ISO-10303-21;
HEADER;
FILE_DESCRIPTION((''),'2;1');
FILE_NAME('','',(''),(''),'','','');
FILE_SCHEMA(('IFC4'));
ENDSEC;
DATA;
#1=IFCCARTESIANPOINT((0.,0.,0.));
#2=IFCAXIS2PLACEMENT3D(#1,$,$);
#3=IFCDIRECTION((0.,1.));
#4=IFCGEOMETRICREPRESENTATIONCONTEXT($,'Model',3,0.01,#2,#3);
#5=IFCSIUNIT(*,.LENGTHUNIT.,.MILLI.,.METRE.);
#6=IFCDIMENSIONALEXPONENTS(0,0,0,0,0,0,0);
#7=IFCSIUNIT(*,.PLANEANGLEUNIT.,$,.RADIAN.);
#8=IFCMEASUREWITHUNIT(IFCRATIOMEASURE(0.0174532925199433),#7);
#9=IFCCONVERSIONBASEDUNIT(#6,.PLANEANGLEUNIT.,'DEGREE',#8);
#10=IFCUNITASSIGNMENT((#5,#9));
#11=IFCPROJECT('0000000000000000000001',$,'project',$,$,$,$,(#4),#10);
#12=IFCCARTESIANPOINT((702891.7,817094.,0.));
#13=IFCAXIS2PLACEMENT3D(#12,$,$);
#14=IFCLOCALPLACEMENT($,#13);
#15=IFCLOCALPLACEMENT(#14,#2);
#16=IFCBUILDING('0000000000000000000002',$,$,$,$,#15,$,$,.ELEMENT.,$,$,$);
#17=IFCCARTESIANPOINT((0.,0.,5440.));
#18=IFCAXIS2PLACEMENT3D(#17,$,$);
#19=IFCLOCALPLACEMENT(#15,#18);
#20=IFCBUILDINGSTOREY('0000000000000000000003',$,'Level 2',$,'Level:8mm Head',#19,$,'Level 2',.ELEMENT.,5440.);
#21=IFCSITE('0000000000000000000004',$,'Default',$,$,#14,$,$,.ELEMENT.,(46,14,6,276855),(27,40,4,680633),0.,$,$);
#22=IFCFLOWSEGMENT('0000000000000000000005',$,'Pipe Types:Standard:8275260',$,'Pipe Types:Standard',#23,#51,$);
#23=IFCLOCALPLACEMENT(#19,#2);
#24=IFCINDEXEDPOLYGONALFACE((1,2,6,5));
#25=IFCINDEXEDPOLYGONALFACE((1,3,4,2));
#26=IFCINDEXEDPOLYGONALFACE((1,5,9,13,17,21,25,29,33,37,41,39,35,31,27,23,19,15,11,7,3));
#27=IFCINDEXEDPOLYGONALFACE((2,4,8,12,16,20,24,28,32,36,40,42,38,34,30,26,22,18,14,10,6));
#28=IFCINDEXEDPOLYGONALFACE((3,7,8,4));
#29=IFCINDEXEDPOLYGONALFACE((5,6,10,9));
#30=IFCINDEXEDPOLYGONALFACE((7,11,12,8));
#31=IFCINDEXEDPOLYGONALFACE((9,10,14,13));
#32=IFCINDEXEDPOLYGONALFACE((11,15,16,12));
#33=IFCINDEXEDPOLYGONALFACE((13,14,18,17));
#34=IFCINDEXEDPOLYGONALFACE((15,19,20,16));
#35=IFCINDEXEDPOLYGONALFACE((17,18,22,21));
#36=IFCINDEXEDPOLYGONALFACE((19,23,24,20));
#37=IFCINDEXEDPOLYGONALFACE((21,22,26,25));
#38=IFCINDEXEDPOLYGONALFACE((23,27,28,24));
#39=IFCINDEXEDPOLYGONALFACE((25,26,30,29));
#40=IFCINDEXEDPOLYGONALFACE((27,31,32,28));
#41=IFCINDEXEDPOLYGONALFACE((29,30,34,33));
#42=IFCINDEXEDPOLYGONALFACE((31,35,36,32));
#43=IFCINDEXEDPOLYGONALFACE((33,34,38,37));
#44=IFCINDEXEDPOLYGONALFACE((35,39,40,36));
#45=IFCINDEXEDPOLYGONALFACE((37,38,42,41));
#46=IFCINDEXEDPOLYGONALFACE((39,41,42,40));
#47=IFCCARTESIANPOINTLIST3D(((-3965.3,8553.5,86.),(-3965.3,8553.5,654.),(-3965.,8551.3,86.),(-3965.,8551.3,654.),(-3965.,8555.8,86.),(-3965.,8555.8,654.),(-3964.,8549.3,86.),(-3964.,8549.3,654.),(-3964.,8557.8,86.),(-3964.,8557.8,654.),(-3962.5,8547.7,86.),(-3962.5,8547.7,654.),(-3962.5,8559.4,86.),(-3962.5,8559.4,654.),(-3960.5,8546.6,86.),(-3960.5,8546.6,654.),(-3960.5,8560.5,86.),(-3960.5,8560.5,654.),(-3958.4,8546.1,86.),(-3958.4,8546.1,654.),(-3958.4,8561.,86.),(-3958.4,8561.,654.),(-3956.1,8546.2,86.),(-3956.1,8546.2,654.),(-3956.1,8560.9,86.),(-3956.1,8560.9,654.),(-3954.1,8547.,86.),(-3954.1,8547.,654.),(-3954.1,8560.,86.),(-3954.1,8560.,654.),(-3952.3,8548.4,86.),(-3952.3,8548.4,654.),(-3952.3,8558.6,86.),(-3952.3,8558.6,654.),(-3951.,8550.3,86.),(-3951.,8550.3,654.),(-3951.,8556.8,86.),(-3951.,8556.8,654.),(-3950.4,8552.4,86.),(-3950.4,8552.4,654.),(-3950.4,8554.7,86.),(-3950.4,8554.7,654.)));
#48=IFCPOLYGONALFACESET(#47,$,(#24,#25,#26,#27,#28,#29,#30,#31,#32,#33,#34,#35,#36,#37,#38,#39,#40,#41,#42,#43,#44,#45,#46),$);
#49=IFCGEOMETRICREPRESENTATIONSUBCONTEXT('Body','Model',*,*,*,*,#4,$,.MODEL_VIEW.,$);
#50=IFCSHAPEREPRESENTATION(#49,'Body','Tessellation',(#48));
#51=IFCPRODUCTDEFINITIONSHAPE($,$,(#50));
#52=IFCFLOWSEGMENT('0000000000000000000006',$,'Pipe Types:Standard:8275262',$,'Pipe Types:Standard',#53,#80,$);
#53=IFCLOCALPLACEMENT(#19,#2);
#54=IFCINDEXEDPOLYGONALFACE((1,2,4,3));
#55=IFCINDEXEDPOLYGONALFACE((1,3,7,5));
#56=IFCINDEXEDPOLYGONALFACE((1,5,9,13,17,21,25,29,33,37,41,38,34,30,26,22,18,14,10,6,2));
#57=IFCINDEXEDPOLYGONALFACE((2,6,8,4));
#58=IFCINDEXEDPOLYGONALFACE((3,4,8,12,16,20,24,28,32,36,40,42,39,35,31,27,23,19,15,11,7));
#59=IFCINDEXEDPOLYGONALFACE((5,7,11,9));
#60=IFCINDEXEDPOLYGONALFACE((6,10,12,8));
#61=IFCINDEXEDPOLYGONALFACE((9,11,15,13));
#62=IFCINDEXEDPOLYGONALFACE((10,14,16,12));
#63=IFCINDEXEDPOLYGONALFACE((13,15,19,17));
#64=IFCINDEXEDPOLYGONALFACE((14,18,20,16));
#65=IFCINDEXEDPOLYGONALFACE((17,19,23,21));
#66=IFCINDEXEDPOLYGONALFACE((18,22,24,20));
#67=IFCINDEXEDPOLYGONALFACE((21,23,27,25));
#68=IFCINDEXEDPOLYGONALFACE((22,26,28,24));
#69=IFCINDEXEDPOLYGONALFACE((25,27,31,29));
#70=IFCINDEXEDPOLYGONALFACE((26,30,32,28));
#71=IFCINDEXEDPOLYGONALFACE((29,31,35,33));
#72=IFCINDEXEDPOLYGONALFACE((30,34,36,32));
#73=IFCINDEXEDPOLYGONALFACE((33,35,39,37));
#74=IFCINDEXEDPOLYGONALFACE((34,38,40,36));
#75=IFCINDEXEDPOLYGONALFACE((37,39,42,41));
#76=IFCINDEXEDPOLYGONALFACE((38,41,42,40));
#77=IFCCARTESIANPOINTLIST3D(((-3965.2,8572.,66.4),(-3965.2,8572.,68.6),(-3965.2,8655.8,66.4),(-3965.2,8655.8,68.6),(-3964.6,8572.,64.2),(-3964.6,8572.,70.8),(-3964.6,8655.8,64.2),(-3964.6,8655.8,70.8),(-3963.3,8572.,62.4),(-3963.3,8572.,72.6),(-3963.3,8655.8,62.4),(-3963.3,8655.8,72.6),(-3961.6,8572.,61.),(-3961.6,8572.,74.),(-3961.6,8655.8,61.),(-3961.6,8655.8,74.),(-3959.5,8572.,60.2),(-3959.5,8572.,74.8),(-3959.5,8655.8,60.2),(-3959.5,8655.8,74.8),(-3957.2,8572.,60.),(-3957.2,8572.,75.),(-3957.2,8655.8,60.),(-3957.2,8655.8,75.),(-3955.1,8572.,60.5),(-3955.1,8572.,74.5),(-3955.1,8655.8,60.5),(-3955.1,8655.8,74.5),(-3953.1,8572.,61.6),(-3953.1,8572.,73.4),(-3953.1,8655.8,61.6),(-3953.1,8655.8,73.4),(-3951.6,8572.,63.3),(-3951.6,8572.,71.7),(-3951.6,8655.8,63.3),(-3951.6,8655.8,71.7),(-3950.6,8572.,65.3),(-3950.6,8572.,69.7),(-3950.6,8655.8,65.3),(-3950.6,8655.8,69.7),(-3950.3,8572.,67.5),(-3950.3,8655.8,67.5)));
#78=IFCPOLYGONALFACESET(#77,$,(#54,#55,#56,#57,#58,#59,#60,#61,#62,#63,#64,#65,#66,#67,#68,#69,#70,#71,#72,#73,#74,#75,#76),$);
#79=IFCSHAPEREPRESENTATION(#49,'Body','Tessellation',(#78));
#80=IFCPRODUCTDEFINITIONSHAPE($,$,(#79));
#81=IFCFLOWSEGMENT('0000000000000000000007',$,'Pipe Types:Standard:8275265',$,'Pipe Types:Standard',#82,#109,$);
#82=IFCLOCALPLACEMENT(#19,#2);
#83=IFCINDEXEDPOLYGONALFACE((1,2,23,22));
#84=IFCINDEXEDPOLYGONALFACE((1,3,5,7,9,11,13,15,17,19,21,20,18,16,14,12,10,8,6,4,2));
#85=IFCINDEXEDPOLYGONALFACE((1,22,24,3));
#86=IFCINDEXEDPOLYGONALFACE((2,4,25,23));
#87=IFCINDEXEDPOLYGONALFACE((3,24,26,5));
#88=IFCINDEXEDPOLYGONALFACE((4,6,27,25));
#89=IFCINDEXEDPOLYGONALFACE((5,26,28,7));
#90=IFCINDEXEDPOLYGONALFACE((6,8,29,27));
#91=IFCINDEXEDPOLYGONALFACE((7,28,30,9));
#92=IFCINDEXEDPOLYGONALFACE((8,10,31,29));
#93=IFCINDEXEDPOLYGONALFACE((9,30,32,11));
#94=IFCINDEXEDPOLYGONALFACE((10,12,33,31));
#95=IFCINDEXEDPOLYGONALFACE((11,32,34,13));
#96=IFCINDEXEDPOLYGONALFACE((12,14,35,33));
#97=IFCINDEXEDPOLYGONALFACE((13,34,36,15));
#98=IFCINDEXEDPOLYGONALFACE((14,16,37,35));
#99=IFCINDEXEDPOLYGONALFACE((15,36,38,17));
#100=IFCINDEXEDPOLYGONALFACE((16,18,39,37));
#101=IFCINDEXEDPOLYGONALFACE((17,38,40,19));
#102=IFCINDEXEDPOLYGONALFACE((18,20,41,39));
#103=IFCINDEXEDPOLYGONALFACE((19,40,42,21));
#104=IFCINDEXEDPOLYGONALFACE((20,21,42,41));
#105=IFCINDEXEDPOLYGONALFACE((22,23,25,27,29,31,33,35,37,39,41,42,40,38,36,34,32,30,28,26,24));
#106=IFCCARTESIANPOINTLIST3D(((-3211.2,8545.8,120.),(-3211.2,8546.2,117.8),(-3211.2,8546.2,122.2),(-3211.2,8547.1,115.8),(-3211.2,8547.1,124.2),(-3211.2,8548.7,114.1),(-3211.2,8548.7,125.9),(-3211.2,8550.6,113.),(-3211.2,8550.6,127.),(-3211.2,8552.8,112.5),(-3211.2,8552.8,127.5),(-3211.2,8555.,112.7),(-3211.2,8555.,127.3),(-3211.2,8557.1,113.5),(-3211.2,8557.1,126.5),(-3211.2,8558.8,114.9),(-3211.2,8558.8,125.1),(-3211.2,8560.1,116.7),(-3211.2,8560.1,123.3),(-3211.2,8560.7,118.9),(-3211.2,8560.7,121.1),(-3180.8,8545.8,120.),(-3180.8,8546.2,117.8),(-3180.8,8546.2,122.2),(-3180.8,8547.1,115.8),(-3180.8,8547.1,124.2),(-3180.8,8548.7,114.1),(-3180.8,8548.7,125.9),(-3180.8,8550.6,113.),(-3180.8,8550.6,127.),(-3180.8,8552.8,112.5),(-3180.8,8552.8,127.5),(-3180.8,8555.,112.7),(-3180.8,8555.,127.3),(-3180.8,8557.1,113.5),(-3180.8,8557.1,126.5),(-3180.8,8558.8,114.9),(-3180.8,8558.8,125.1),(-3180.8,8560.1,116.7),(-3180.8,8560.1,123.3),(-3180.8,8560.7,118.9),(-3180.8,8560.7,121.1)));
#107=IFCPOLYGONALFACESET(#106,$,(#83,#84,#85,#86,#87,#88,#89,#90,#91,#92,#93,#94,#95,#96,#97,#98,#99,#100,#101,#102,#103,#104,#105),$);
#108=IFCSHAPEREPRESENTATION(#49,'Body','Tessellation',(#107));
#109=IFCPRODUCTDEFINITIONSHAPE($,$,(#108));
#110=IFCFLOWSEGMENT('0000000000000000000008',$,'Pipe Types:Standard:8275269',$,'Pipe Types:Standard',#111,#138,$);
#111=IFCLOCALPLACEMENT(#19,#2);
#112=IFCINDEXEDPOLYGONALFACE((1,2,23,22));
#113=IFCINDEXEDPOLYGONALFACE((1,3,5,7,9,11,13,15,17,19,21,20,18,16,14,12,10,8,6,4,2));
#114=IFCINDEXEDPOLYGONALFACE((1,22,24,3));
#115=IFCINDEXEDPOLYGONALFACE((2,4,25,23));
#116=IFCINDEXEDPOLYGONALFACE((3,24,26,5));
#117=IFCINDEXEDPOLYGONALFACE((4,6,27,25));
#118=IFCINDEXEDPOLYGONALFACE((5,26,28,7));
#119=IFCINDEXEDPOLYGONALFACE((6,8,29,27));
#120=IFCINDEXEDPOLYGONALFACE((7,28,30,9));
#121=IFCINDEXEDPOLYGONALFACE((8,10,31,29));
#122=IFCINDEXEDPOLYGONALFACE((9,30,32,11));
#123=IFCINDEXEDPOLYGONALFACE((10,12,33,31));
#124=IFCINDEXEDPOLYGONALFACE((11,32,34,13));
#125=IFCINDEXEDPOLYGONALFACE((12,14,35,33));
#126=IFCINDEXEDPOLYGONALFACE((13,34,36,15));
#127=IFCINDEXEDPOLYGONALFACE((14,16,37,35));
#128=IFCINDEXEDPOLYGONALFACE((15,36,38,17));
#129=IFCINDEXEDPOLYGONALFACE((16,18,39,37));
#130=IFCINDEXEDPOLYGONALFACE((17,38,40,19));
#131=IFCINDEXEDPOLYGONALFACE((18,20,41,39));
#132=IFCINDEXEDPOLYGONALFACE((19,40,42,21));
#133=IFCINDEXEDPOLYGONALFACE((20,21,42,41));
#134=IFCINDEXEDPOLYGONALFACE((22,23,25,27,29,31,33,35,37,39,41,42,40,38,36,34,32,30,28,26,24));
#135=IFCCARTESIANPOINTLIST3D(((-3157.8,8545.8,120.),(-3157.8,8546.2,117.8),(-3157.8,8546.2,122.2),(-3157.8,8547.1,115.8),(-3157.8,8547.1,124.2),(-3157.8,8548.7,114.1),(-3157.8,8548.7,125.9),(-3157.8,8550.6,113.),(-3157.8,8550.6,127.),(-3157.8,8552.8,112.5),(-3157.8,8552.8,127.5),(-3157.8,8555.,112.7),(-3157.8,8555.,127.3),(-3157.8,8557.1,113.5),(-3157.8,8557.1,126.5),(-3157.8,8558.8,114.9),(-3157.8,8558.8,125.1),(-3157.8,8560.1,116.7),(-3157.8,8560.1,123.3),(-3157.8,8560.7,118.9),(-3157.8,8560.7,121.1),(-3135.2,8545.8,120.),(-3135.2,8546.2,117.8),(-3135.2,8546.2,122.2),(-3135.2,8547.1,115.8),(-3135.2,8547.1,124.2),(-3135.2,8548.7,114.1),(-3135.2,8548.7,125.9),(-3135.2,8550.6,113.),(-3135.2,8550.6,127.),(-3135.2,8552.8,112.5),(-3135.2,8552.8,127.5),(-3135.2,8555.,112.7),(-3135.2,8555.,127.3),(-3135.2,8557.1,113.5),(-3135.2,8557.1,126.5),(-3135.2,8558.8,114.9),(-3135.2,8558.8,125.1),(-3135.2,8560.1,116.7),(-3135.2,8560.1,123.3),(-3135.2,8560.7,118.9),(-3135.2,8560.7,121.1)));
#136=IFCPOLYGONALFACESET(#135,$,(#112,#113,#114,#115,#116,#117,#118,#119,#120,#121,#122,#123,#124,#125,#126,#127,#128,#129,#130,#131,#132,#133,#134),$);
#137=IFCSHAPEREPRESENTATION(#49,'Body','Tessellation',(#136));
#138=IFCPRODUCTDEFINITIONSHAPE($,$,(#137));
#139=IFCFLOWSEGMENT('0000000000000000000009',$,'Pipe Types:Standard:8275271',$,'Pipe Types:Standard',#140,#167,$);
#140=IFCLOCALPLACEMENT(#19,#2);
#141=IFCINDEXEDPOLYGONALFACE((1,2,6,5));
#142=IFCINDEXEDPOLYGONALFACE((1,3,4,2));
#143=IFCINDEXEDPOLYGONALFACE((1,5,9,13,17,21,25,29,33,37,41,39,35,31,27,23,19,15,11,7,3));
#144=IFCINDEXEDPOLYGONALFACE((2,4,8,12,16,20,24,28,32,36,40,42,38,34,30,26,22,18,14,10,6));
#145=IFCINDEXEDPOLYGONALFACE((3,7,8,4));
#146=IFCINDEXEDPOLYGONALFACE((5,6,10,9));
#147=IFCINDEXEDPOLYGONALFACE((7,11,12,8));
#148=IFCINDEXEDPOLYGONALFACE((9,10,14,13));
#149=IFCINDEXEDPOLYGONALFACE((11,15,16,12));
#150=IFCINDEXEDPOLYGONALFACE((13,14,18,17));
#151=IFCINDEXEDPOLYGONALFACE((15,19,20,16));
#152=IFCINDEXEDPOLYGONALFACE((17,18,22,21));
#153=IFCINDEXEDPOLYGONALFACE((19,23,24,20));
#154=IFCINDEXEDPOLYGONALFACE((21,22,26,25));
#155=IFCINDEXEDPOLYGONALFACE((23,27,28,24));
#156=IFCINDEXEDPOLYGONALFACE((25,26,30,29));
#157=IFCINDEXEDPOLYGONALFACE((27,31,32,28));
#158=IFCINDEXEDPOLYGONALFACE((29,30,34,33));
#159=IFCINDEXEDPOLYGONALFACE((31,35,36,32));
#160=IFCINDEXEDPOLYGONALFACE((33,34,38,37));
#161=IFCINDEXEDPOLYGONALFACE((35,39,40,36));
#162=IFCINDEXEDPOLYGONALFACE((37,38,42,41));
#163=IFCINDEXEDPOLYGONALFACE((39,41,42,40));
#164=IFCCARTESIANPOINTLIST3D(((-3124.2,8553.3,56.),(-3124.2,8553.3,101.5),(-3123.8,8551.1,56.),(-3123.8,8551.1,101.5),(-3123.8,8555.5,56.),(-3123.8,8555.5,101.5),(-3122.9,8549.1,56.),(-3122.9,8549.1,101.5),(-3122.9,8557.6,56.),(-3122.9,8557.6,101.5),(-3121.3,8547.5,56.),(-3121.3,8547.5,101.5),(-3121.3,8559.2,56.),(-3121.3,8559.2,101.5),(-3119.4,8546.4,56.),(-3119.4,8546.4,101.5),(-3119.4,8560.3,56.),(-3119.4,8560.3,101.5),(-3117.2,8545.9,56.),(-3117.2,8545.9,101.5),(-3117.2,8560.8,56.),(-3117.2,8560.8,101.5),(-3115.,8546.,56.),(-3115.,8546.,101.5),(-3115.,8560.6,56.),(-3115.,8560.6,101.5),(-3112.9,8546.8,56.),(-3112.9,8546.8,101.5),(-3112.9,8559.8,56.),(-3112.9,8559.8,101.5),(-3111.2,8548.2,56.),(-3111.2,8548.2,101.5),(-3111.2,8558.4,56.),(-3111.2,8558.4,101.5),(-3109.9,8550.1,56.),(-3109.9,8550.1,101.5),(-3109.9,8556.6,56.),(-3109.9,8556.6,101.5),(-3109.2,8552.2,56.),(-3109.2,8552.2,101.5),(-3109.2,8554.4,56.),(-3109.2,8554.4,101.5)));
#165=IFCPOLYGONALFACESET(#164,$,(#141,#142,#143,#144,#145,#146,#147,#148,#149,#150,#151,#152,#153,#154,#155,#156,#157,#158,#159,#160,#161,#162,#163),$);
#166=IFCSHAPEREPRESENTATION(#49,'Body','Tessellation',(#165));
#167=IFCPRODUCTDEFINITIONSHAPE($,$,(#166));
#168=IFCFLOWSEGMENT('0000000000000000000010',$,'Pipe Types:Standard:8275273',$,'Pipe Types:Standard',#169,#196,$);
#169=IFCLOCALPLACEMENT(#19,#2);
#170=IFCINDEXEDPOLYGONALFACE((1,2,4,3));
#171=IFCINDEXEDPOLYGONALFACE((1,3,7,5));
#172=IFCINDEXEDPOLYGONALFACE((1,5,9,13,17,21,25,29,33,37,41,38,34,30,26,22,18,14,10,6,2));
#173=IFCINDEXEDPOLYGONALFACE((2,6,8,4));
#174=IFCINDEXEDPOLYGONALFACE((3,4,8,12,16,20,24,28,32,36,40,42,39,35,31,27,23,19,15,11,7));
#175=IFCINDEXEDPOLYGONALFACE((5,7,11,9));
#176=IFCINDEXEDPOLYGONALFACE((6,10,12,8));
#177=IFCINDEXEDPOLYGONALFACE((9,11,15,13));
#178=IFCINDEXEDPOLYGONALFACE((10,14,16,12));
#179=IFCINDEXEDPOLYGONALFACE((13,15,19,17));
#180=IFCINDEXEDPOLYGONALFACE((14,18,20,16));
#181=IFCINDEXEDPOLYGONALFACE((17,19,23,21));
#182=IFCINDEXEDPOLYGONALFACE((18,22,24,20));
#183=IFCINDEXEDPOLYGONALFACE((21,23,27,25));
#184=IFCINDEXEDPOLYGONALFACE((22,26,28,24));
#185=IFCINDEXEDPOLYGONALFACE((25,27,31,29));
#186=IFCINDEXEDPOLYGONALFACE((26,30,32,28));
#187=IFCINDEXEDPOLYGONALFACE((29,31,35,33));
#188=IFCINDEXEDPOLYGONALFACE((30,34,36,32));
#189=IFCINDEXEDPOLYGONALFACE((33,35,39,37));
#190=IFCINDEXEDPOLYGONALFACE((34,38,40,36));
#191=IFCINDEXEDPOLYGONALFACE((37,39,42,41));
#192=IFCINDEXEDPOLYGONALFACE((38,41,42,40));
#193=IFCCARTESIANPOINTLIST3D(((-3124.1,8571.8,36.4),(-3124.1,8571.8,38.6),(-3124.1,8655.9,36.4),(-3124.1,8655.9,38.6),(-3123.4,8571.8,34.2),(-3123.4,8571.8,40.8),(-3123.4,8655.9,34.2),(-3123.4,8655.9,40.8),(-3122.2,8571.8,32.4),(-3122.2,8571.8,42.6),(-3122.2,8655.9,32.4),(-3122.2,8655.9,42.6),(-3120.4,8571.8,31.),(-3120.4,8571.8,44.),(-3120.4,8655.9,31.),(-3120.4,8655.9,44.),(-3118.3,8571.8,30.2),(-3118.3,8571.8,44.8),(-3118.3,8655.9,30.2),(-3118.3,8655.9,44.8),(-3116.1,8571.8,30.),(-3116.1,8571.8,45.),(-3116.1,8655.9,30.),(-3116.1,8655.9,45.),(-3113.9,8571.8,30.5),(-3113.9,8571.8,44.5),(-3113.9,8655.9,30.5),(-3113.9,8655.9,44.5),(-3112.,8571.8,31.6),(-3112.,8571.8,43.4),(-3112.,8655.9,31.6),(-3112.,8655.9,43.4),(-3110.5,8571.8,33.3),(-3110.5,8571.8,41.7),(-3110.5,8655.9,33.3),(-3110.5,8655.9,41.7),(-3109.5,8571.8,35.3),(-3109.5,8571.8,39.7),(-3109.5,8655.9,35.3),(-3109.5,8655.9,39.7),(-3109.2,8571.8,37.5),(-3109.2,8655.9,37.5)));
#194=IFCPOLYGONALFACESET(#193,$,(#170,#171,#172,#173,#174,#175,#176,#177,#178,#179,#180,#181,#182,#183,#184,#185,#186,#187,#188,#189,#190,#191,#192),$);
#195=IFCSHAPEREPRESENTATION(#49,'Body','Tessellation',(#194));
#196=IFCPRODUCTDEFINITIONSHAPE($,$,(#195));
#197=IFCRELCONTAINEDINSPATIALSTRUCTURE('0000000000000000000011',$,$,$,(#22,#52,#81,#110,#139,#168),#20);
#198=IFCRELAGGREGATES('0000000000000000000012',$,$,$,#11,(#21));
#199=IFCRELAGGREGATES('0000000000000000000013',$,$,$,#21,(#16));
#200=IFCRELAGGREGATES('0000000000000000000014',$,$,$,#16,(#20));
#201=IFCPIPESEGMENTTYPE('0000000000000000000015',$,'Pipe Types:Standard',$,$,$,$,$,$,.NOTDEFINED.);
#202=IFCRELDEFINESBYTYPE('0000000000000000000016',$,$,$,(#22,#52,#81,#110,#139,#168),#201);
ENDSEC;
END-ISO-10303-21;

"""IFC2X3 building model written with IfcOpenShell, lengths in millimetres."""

from ifc_helpers import new_model, entity, si_unit, converted_unit, direction, frame, origin, origin_2d_with_axis, place, context, subcontext, project, spatial, circle, extrude, type_object, element, save


model = new_model("IFC2X3")

# Units and contexts
model_context = context("Model", 3, precision=0.01, world=origin(), true_north=direction((0.0, 1.0)))
body_context = subcontext(model_context, "Body", "Model", "MODEL_VIEW")
ifc_project = project(units=[si_unit("LENGTHUNIT", "METRE", prefix="MILLI"), converted_unit("PLANEANGLEUNIT", "DEGREE", entity("IfcRatioMeasure", 0.0174532925199433), si_unit("PLANEANGLEUNIT", "RADIAN"), dimensions=[0, 0, 0, 0, 0, 0, 0])], contexts=[model_context])

# Site, building, storey
site_placement = place(None, frame((702891.7, 817094.0, 0.0)))
site = spatial("IfcSite", under=ifc_project, at=site_placement, Name="Default", CompositionType="ELEMENT", RefLatitude=(46, 14, 6, 276855), RefLongitude=(27, 40, 4, 680633), RefElevation=0.0)
building_placement = place(site_placement, origin())
building = spatial("IfcBuilding", under=site, at=building_placement, CompositionType="ELEMENT")
storey_placement = place(building_placement, frame((0.0, 0.0, 5440.0)))
storey = spatial("IfcBuildingStorey", under=building, at=storey_placement, Name="Level 2", ObjectType="Level:8mm Head", LongName="Level 2", CompositionType="ELEMENT", Elevation=5440.0)

# Flow segments
pipe_segment_type = type_object("IfcPipeSegmentType", Name="Pipe Types:Standard", PredefinedType="NOTDEFINED")
flow_segment_1_placement = place(storey_placement, origin())
element("IfcFlowSegment", 1, at=flow_segment_1_placement, inside=storey, type_object=pipe_segment_type, Name="Pipe Types:Standard:8275260", ObjectType="Pipe Types:Standard", context=body_context, shape_type="SweptSolid", body=[
    extrude(circle(Radius=7.5, at=origin_2d_with_axis()), frame((-3957.8, 8553.5, 86.0), z_axis=(0.0, 0.0, 1.0), x_axis=(-1.0, 0.0, 0.0)), (0.0, 0.0, 1.0), 568.0),
])
flow_segment_2_placement = place(storey_placement, origin())
element("IfcFlowSegment", 2, at=flow_segment_2_placement, inside=storey, type_object=pipe_segment_type, Name="Pipe Types:Standard:8275262", ObjectType="Pipe Types:Standard", context=body_context, shape_type="SweptSolid", body=[
    extrude(circle(Radius=7.5, at=origin_2d_with_axis()), frame((-3957.8, 8655.8, 67.5), z_axis=(0.000043, -1.0, 0.0), x_axis=(1.0, 0.000043, 0.0)), (0.0, 0.0, 1.0), 83.8),
])
flow_segment_3_placement = place(storey_placement, origin())
element("IfcFlowSegment", 3, at=flow_segment_3_placement, inside=storey, type_object=pipe_segment_type, Name="Pipe Types:Standard:8275265", ObjectType="Pipe Types:Standard", context=body_context, shape_type="SweptSolid", body=[
    extrude(circle(Radius=7.5, at=origin_2d_with_axis()), frame((-3211.2, 8553.3, 120.0), z_axis=(1.0, 0.000024, 0.0), x_axis=(0.000024, -1.0, 0.0)), (0.0, 0.0, 1.0), 30.4),
])
flow_segment_4_placement = place(storey_placement, origin())
element("IfcFlowSegment", 4, at=flow_segment_4_placement, inside=storey, type_object=pipe_segment_type, Name="Pipe Types:Standard:8275269", ObjectType="Pipe Types:Standard", context=body_context, shape_type="SweptSolid", body=[
    extrude(circle(Radius=7.5, at=origin_2d_with_axis()), frame((-3157.8, 8553.3, 120.0), z_axis=(1.0, 0.000024, 0.0), x_axis=(0.000024, -1.0, 0.0)), (0.0, 0.0, 1.0), 22.6),
])
flow_segment_5_placement = place(storey_placement, origin())
element("IfcFlowSegment", 5, at=flow_segment_5_placement, inside=storey, type_object=pipe_segment_type, Name="Pipe Types:Standard:8275271", ObjectType="Pipe Types:Standard", context=body_context, shape_type="SweptSolid", body=[
    extrude(circle(Radius=7.5, at=origin_2d_with_axis()), frame((-3116.7, 8553.3, 56.0), z_axis=(0.0, 0.0, 1.0), x_axis=(-1.0, 0.0, 0.0)), (0.0, 0.0, 1.0), 45.5),
])
flow_segment_6_placement = place(storey_placement, origin())
element("IfcFlowSegment", 6, at=flow_segment_6_placement, inside=storey, type_object=pipe_segment_type, Name="Pipe Types:Standard:8275273", ObjectType="Pipe Types:Standard", context=body_context, shape_type="SweptSolid", body=[
    extrude(circle(Radius=7.5, at=origin_2d_with_axis()), frame((-3116.7, 8571.8, 37.5), z_axis=(0.000036, 1.0, 0.0), x_axis=(1.0, -0.000036, 0.0)), (0.0, 0.0, 1.0), 84.0),
])

save(model, "model.ifc")
